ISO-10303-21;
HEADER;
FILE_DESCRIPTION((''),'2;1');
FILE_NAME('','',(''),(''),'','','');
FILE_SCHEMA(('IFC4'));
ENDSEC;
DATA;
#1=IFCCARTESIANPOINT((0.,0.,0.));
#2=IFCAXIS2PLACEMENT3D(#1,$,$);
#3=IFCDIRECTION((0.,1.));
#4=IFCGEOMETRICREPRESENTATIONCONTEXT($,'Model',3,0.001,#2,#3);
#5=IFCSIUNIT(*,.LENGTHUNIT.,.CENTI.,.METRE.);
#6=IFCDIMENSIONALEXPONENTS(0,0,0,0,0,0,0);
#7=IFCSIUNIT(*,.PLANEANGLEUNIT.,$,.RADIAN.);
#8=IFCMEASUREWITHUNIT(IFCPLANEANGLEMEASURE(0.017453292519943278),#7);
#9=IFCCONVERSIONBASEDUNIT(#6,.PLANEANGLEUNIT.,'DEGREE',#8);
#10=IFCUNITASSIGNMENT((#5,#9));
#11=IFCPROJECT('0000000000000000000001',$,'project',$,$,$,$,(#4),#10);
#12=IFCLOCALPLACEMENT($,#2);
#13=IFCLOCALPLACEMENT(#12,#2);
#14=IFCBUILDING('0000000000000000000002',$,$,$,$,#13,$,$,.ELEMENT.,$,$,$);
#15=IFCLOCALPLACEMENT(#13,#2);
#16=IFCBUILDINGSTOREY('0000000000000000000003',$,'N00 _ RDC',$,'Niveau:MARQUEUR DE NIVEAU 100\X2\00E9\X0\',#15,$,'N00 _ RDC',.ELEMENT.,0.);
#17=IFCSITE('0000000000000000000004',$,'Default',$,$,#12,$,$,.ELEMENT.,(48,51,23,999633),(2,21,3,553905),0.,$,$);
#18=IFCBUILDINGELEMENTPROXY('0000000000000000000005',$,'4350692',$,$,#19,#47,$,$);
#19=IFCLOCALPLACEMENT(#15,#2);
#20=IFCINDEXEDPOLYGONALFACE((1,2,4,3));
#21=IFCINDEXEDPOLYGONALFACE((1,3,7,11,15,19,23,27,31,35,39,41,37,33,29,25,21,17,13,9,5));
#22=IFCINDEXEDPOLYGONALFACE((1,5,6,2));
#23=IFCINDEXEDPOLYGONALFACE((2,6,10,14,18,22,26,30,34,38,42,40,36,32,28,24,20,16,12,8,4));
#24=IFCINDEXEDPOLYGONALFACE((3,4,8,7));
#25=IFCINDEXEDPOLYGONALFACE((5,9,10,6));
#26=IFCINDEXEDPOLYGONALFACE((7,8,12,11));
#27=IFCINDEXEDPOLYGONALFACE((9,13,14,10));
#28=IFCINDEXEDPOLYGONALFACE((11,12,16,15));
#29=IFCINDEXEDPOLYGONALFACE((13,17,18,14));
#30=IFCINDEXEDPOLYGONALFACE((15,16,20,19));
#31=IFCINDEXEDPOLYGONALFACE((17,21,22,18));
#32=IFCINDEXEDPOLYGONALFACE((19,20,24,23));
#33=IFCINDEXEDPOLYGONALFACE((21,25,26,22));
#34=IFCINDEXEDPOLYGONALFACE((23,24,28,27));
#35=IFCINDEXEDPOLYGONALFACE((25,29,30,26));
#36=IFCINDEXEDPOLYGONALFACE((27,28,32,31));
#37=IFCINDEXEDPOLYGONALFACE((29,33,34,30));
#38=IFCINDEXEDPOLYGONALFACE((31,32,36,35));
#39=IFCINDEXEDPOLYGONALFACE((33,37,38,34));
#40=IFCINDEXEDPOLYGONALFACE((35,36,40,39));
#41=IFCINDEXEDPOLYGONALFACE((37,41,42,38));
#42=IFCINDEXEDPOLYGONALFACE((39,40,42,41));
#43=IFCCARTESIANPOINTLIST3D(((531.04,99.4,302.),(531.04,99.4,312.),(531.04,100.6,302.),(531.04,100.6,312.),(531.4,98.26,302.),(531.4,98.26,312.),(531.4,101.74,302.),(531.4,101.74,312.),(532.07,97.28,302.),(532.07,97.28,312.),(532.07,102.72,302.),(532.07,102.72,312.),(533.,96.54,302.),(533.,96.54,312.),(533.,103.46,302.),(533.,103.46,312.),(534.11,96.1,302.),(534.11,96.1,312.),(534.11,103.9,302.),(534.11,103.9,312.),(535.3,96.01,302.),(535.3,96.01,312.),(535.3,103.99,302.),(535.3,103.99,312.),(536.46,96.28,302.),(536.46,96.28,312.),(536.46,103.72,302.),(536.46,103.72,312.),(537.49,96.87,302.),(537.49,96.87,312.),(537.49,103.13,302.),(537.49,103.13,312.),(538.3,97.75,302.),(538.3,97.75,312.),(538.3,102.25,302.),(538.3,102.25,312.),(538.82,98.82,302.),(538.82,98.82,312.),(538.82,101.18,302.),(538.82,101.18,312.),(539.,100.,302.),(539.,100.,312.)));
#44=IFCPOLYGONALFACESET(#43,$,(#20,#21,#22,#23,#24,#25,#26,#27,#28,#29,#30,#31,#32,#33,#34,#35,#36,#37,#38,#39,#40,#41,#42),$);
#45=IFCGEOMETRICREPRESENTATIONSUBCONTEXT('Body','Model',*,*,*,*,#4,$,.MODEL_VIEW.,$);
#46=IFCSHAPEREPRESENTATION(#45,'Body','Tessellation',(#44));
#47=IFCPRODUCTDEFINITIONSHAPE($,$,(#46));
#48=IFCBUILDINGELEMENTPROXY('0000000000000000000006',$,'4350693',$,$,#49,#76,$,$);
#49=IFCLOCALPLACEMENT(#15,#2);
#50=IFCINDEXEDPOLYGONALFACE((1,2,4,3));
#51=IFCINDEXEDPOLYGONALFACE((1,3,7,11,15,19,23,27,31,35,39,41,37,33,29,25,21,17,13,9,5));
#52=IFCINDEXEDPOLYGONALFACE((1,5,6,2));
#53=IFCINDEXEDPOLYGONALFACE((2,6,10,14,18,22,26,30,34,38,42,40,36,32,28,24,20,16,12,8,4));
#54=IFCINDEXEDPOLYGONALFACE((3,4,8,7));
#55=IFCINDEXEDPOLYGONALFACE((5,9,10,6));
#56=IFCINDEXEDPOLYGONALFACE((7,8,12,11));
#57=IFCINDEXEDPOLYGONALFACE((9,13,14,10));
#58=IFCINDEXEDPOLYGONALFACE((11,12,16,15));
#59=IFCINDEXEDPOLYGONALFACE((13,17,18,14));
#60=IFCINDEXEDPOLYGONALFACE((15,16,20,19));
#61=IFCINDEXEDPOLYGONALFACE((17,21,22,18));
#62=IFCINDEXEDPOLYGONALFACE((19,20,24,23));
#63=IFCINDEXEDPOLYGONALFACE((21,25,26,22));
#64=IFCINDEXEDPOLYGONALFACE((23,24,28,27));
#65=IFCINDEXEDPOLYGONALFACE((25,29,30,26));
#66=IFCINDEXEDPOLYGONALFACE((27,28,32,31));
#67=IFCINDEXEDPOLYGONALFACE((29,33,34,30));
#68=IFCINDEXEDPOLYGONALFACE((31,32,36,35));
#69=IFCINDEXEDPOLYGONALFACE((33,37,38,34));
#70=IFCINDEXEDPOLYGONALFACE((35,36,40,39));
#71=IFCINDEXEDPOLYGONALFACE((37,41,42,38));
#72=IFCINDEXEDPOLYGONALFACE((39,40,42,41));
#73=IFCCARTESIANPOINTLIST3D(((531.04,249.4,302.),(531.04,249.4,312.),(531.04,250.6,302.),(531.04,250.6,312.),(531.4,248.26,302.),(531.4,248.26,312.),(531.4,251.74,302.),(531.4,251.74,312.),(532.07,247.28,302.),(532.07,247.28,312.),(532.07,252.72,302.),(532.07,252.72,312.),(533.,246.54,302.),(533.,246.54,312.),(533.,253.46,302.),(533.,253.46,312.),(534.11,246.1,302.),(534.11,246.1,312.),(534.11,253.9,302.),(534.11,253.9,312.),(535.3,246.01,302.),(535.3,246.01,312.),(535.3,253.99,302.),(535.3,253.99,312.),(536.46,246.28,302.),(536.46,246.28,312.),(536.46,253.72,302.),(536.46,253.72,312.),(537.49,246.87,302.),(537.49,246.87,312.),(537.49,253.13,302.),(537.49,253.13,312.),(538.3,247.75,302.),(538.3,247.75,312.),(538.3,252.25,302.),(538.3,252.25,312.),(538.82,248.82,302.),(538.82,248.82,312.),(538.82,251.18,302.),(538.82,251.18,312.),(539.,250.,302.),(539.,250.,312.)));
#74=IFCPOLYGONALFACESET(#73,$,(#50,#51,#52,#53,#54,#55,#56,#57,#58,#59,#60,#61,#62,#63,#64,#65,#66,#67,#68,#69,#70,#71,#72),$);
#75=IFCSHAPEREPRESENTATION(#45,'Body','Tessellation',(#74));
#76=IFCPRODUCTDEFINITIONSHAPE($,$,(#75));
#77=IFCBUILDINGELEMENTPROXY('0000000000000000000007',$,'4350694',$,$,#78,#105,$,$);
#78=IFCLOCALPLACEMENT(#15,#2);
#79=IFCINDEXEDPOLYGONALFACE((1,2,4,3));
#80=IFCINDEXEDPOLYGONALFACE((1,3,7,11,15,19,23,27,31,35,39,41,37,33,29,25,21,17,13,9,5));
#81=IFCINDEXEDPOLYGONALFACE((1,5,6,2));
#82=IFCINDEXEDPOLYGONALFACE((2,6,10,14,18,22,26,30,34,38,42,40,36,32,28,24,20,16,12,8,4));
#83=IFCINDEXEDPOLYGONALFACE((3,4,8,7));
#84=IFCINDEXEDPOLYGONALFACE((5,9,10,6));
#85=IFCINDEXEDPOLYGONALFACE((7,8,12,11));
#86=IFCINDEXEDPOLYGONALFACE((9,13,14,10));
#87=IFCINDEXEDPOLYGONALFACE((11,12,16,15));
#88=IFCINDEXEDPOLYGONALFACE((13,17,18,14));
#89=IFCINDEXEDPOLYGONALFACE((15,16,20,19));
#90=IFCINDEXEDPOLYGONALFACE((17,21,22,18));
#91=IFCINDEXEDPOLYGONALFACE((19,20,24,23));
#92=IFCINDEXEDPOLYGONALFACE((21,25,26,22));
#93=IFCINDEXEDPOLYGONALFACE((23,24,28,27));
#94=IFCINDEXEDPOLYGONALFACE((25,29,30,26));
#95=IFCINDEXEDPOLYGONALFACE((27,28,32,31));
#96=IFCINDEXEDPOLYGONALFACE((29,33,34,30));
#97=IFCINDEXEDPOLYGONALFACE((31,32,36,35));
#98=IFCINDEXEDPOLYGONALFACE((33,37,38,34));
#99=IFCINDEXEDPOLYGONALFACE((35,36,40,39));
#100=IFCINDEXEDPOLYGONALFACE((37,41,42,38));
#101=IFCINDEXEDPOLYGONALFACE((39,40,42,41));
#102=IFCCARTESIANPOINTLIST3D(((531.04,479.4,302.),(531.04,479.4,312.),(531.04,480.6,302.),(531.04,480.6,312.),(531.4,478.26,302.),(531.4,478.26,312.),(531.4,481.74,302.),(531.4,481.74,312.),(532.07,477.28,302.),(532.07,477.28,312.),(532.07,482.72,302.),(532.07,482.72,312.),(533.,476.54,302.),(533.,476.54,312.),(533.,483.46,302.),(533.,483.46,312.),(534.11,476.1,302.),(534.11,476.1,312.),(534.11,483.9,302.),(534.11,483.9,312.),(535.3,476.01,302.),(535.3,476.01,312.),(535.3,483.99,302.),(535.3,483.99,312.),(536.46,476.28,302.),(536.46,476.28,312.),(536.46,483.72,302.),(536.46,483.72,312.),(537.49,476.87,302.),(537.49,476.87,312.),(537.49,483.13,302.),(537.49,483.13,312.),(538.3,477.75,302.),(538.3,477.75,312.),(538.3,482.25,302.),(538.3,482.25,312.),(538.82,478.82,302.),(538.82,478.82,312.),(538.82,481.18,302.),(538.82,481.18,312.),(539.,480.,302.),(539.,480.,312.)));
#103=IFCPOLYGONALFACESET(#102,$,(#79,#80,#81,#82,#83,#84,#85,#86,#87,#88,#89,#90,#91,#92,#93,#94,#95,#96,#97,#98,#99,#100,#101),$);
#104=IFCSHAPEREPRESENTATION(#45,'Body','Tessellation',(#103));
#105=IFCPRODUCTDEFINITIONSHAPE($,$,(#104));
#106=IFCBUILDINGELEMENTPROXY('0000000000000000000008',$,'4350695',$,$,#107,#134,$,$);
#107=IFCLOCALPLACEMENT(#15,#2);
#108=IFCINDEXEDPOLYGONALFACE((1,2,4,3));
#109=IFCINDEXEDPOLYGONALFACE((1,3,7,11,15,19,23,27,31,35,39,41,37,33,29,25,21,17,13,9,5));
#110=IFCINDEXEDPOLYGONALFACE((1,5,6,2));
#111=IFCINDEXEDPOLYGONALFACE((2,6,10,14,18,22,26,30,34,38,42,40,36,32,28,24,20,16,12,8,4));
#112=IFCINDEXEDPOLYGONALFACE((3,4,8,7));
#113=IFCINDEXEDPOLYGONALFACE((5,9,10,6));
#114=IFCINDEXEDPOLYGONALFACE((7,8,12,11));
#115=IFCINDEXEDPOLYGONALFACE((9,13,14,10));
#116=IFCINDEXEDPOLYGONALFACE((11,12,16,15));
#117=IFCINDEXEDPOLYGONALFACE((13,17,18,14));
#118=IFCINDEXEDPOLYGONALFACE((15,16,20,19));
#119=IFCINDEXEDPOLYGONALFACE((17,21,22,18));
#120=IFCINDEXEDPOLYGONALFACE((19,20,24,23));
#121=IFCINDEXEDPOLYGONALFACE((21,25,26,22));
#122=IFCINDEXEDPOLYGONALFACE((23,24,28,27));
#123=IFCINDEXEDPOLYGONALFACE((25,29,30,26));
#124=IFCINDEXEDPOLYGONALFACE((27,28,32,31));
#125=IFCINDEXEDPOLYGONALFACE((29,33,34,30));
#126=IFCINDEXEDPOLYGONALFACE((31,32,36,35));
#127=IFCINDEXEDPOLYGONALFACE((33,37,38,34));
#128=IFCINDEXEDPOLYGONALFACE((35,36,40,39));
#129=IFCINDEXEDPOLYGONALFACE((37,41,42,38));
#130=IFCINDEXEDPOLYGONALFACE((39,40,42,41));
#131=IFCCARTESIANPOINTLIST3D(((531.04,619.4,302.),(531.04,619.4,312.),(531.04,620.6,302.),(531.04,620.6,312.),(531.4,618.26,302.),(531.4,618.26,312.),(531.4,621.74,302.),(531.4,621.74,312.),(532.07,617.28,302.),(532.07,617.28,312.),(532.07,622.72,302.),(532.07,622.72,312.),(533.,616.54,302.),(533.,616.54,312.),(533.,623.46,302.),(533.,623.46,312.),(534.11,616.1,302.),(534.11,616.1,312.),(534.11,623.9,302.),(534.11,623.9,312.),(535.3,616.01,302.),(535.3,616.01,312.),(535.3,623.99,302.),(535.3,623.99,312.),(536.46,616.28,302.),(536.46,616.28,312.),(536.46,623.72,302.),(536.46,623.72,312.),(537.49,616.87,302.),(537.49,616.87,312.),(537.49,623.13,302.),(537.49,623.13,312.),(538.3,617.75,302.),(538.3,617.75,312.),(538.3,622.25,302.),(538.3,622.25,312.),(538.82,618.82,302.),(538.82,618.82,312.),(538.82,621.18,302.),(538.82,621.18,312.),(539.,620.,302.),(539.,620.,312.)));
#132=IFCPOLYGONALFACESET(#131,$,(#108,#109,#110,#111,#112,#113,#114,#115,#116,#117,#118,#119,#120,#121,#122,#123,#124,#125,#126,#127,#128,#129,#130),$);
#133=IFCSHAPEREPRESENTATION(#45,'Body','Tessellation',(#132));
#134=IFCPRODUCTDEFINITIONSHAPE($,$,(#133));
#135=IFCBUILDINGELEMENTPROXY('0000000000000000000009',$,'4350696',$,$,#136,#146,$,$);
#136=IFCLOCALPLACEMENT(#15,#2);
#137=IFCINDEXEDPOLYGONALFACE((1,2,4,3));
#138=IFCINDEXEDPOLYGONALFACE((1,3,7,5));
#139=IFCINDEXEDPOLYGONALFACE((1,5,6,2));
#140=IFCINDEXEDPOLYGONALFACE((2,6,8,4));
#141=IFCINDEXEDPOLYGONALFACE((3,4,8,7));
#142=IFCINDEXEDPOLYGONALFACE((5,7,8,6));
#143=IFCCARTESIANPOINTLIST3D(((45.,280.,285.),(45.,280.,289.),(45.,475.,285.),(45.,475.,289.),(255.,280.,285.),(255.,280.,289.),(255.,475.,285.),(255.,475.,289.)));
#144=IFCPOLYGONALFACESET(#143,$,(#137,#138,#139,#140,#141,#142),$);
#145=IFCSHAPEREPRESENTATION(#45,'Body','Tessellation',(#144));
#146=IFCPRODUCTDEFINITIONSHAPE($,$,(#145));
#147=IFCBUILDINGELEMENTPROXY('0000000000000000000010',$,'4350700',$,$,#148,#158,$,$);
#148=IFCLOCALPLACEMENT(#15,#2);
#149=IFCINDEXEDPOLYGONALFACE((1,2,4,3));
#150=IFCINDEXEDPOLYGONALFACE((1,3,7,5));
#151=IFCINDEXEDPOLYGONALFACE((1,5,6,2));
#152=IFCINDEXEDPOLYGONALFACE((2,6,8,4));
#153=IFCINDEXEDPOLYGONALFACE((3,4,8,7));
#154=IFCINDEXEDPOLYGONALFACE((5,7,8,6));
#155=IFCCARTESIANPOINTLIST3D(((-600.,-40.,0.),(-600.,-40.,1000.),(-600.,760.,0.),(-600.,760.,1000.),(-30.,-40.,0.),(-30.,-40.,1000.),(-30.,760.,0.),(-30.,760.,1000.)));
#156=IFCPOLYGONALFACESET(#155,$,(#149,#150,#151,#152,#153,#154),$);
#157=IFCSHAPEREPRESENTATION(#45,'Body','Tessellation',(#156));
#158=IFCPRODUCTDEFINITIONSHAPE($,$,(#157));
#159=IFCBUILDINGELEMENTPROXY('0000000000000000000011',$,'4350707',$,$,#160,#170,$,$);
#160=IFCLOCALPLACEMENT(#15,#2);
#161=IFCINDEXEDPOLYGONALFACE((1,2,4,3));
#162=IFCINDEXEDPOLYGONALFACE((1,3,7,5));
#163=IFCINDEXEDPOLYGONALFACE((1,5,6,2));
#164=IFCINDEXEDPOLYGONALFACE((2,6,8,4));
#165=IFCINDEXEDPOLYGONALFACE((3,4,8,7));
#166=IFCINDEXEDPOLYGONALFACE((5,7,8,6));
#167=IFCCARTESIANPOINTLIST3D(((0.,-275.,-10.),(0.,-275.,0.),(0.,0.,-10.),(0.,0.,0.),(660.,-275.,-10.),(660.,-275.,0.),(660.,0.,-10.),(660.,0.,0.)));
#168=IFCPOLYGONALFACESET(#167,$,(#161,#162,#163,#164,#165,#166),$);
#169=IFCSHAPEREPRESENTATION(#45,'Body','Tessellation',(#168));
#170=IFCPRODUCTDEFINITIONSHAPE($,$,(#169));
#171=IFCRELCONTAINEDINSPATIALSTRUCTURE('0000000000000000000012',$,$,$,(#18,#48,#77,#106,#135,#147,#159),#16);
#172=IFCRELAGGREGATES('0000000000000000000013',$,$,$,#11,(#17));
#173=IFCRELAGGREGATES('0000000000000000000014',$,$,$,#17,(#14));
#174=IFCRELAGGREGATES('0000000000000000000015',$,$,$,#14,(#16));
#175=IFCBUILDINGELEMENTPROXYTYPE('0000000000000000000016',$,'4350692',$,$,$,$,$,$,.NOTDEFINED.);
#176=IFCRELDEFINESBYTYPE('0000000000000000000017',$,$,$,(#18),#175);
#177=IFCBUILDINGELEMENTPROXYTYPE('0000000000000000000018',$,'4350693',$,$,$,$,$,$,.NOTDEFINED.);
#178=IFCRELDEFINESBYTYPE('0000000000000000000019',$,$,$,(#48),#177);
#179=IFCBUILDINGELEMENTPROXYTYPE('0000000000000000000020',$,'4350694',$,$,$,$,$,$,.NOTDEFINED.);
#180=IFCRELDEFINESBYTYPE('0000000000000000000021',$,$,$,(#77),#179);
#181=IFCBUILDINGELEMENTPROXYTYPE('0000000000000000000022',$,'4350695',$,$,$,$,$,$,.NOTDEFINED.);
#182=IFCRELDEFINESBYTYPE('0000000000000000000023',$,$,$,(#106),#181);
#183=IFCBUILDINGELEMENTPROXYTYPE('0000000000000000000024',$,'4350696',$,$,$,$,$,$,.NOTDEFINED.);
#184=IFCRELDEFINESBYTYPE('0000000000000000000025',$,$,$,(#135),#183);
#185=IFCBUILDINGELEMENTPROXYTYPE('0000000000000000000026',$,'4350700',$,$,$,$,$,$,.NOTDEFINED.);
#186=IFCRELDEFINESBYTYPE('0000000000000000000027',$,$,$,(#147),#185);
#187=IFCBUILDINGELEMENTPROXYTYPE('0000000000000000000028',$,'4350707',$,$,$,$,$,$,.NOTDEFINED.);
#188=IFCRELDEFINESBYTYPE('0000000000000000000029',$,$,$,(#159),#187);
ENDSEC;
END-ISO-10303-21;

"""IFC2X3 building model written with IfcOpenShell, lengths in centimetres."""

from ifc_helpers import new_model, entity, si_unit, converted_unit, direction, frame, frame_2d, origin, origin_2d_with_axis, place, context, subcontext, project, spatial, rectangle, circle, extrude, type_object, element, save


model = new_model("IFC2X3")

# Units and contexts
model_context = context("Model", 3, precision=0.001, world=origin(), true_north=direction((0.0, 1.0)))
body_context = subcontext(model_context, "Body", "Model", "MODEL_VIEW")
ifc_project = project(units=[si_unit("LENGTHUNIT", "METRE", prefix="CENTI"), converted_unit("PLANEANGLEUNIT", "DEGREE", entity("IfcPlaneAngleMeasure", 0.017453292519943278), si_unit("PLANEANGLEUNIT", "RADIAN"), dimensions=[0, 0, 0, 0, 0, 0, 0])], contexts=[model_context])

# Site, building, storey
site_placement = place(None, origin())
site = spatial("IfcSite", under=ifc_project, at=site_placement, Name="Default", CompositionType="ELEMENT", RefLatitude=(48, 51, 23, 999633), RefLongitude=(2, 21, 3, 553905), RefElevation=0.0)
building_placement = place(site_placement, origin())
building = spatial("IfcBuilding", under=site, at=building_placement, CompositionType="ELEMENT")
storey_placement = place(building_placement, origin())
storey = spatial("IfcBuildingStorey", under=building, at=storey_placement, Name="N00 _ RDC", ObjectType="Niveau:MARQUEUR DE NIVEAU 100é", LongName="N00 _ RDC", CompositionType="ELEMENT", Elevation=0.0)

# Building element proxies
building_element_proxy_type_1 = type_object("IfcBuildingElementProxyType", Name="4350692", PredefinedType="NOTDEFINED")
proxy_1_placement = place(storey_placement, origin())
element("IfcBuildingElementProxy", 1, at=proxy_1_placement, inside=storey, type_object=building_element_proxy_type_1, Name="4350692", context=body_context, shape_type="SweptSolid", body=[
    extrude(circle(Radius=4.0, at=origin_2d_with_axis()), frame((535.0, 100.0, 302.0)), (0.0, 0.0, 1.0), 10.0),
])
building_element_proxy_type_2 = type_object("IfcBuildingElementProxyType", Name="4350693", PredefinedType="NOTDEFINED")
proxy_2_placement = place(storey_placement, origin())
element("IfcBuildingElementProxy", 2, at=proxy_2_placement, inside=storey, type_object=building_element_proxy_type_2, Name="4350693", context=body_context, shape_type="SweptSolid", body=[
    extrude(circle(Radius=4.0, at=origin_2d_with_axis()), frame((535.0, 250.0, 302.0)), (0.0, 0.0, 1.0), 10.0),
])
building_element_proxy_type_3 = type_object("IfcBuildingElementProxyType", Name="4350694", PredefinedType="NOTDEFINED")
proxy_3_placement = place(storey_placement, origin())
element("IfcBuildingElementProxy", 3, at=proxy_3_placement, inside=storey, type_object=building_element_proxy_type_3, Name="4350694", context=body_context, shape_type="SweptSolid", body=[
    extrude(circle(Radius=4.0, at=origin_2d_with_axis()), frame((535.0, 480.0, 302.0)), (0.0, 0.0, 1.0), 10.0),
])
building_element_proxy_type_4 = type_object("IfcBuildingElementProxyType", Name="4350695", PredefinedType="NOTDEFINED")
proxy_4_placement = place(storey_placement, origin())
element("IfcBuildingElementProxy", 4, at=proxy_4_placement, inside=storey, type_object=building_element_proxy_type_4, Name="4350695", context=body_context, shape_type="SweptSolid", body=[
    extrude(circle(Radius=4.0, at=origin_2d_with_axis()), frame((535.0, 620.0, 302.0)), (0.0, 0.0, 1.0), 10.0),
])
building_element_proxy_type_5 = type_object("IfcBuildingElementProxyType", Name="4350696", PredefinedType="NOTDEFINED")
proxy_5_placement = place(storey_placement, origin())
element("IfcBuildingElementProxy", 5, at=proxy_5_placement, inside=storey, type_object=building_element_proxy_type_5, Name="4350696", context=body_context, shape_type="SweptSolid", body=[
    extrude(rectangle(XDim=210.0, YDim=195.0, at=frame_2d((0.0, 0.0), x_axis=(1.0, 0.0))), frame((150.0, 377.5, 285.0)), (0.0, 0.0, 1.0), 4.0),
])
building_element_proxy_type_6 = type_object("IfcBuildingElementProxyType", Name="4350700", PredefinedType="NOTDEFINED")
proxy_6_placement = place(storey_placement, origin())
element("IfcBuildingElementProxy", 6, at=proxy_6_placement, inside=storey, type_object=building_element_proxy_type_6, Name="4350700", context=body_context, shape_type="SweptSolid", body=[
    extrude(rectangle(XDim=570.0, YDim=800.0, at=origin_2d_with_axis()), frame((-315.0, 360.0, 0.0)), (0.0, 0.0, 1.0), 1000.0),
])
building_element_proxy_type_7 = type_object("IfcBuildingElementProxyType", Name="4350707", PredefinedType="NOTDEFINED")
proxy_7_placement = place(storey_placement, origin())
element("IfcBuildingElementProxy", 7, at=proxy_7_placement, inside=storey, type_object=building_element_proxy_type_7, Name="4350707", context=body_context, shape_type="SweptSolid", body=[
    extrude(rectangle(XDim=660.0, YDim=275.0, at=origin_2d_with_axis()), frame((330.0, -137.5, -10.0)), (0.0, 0.0, 1.0), 10.0),
])

save(model, "model.ifc")
